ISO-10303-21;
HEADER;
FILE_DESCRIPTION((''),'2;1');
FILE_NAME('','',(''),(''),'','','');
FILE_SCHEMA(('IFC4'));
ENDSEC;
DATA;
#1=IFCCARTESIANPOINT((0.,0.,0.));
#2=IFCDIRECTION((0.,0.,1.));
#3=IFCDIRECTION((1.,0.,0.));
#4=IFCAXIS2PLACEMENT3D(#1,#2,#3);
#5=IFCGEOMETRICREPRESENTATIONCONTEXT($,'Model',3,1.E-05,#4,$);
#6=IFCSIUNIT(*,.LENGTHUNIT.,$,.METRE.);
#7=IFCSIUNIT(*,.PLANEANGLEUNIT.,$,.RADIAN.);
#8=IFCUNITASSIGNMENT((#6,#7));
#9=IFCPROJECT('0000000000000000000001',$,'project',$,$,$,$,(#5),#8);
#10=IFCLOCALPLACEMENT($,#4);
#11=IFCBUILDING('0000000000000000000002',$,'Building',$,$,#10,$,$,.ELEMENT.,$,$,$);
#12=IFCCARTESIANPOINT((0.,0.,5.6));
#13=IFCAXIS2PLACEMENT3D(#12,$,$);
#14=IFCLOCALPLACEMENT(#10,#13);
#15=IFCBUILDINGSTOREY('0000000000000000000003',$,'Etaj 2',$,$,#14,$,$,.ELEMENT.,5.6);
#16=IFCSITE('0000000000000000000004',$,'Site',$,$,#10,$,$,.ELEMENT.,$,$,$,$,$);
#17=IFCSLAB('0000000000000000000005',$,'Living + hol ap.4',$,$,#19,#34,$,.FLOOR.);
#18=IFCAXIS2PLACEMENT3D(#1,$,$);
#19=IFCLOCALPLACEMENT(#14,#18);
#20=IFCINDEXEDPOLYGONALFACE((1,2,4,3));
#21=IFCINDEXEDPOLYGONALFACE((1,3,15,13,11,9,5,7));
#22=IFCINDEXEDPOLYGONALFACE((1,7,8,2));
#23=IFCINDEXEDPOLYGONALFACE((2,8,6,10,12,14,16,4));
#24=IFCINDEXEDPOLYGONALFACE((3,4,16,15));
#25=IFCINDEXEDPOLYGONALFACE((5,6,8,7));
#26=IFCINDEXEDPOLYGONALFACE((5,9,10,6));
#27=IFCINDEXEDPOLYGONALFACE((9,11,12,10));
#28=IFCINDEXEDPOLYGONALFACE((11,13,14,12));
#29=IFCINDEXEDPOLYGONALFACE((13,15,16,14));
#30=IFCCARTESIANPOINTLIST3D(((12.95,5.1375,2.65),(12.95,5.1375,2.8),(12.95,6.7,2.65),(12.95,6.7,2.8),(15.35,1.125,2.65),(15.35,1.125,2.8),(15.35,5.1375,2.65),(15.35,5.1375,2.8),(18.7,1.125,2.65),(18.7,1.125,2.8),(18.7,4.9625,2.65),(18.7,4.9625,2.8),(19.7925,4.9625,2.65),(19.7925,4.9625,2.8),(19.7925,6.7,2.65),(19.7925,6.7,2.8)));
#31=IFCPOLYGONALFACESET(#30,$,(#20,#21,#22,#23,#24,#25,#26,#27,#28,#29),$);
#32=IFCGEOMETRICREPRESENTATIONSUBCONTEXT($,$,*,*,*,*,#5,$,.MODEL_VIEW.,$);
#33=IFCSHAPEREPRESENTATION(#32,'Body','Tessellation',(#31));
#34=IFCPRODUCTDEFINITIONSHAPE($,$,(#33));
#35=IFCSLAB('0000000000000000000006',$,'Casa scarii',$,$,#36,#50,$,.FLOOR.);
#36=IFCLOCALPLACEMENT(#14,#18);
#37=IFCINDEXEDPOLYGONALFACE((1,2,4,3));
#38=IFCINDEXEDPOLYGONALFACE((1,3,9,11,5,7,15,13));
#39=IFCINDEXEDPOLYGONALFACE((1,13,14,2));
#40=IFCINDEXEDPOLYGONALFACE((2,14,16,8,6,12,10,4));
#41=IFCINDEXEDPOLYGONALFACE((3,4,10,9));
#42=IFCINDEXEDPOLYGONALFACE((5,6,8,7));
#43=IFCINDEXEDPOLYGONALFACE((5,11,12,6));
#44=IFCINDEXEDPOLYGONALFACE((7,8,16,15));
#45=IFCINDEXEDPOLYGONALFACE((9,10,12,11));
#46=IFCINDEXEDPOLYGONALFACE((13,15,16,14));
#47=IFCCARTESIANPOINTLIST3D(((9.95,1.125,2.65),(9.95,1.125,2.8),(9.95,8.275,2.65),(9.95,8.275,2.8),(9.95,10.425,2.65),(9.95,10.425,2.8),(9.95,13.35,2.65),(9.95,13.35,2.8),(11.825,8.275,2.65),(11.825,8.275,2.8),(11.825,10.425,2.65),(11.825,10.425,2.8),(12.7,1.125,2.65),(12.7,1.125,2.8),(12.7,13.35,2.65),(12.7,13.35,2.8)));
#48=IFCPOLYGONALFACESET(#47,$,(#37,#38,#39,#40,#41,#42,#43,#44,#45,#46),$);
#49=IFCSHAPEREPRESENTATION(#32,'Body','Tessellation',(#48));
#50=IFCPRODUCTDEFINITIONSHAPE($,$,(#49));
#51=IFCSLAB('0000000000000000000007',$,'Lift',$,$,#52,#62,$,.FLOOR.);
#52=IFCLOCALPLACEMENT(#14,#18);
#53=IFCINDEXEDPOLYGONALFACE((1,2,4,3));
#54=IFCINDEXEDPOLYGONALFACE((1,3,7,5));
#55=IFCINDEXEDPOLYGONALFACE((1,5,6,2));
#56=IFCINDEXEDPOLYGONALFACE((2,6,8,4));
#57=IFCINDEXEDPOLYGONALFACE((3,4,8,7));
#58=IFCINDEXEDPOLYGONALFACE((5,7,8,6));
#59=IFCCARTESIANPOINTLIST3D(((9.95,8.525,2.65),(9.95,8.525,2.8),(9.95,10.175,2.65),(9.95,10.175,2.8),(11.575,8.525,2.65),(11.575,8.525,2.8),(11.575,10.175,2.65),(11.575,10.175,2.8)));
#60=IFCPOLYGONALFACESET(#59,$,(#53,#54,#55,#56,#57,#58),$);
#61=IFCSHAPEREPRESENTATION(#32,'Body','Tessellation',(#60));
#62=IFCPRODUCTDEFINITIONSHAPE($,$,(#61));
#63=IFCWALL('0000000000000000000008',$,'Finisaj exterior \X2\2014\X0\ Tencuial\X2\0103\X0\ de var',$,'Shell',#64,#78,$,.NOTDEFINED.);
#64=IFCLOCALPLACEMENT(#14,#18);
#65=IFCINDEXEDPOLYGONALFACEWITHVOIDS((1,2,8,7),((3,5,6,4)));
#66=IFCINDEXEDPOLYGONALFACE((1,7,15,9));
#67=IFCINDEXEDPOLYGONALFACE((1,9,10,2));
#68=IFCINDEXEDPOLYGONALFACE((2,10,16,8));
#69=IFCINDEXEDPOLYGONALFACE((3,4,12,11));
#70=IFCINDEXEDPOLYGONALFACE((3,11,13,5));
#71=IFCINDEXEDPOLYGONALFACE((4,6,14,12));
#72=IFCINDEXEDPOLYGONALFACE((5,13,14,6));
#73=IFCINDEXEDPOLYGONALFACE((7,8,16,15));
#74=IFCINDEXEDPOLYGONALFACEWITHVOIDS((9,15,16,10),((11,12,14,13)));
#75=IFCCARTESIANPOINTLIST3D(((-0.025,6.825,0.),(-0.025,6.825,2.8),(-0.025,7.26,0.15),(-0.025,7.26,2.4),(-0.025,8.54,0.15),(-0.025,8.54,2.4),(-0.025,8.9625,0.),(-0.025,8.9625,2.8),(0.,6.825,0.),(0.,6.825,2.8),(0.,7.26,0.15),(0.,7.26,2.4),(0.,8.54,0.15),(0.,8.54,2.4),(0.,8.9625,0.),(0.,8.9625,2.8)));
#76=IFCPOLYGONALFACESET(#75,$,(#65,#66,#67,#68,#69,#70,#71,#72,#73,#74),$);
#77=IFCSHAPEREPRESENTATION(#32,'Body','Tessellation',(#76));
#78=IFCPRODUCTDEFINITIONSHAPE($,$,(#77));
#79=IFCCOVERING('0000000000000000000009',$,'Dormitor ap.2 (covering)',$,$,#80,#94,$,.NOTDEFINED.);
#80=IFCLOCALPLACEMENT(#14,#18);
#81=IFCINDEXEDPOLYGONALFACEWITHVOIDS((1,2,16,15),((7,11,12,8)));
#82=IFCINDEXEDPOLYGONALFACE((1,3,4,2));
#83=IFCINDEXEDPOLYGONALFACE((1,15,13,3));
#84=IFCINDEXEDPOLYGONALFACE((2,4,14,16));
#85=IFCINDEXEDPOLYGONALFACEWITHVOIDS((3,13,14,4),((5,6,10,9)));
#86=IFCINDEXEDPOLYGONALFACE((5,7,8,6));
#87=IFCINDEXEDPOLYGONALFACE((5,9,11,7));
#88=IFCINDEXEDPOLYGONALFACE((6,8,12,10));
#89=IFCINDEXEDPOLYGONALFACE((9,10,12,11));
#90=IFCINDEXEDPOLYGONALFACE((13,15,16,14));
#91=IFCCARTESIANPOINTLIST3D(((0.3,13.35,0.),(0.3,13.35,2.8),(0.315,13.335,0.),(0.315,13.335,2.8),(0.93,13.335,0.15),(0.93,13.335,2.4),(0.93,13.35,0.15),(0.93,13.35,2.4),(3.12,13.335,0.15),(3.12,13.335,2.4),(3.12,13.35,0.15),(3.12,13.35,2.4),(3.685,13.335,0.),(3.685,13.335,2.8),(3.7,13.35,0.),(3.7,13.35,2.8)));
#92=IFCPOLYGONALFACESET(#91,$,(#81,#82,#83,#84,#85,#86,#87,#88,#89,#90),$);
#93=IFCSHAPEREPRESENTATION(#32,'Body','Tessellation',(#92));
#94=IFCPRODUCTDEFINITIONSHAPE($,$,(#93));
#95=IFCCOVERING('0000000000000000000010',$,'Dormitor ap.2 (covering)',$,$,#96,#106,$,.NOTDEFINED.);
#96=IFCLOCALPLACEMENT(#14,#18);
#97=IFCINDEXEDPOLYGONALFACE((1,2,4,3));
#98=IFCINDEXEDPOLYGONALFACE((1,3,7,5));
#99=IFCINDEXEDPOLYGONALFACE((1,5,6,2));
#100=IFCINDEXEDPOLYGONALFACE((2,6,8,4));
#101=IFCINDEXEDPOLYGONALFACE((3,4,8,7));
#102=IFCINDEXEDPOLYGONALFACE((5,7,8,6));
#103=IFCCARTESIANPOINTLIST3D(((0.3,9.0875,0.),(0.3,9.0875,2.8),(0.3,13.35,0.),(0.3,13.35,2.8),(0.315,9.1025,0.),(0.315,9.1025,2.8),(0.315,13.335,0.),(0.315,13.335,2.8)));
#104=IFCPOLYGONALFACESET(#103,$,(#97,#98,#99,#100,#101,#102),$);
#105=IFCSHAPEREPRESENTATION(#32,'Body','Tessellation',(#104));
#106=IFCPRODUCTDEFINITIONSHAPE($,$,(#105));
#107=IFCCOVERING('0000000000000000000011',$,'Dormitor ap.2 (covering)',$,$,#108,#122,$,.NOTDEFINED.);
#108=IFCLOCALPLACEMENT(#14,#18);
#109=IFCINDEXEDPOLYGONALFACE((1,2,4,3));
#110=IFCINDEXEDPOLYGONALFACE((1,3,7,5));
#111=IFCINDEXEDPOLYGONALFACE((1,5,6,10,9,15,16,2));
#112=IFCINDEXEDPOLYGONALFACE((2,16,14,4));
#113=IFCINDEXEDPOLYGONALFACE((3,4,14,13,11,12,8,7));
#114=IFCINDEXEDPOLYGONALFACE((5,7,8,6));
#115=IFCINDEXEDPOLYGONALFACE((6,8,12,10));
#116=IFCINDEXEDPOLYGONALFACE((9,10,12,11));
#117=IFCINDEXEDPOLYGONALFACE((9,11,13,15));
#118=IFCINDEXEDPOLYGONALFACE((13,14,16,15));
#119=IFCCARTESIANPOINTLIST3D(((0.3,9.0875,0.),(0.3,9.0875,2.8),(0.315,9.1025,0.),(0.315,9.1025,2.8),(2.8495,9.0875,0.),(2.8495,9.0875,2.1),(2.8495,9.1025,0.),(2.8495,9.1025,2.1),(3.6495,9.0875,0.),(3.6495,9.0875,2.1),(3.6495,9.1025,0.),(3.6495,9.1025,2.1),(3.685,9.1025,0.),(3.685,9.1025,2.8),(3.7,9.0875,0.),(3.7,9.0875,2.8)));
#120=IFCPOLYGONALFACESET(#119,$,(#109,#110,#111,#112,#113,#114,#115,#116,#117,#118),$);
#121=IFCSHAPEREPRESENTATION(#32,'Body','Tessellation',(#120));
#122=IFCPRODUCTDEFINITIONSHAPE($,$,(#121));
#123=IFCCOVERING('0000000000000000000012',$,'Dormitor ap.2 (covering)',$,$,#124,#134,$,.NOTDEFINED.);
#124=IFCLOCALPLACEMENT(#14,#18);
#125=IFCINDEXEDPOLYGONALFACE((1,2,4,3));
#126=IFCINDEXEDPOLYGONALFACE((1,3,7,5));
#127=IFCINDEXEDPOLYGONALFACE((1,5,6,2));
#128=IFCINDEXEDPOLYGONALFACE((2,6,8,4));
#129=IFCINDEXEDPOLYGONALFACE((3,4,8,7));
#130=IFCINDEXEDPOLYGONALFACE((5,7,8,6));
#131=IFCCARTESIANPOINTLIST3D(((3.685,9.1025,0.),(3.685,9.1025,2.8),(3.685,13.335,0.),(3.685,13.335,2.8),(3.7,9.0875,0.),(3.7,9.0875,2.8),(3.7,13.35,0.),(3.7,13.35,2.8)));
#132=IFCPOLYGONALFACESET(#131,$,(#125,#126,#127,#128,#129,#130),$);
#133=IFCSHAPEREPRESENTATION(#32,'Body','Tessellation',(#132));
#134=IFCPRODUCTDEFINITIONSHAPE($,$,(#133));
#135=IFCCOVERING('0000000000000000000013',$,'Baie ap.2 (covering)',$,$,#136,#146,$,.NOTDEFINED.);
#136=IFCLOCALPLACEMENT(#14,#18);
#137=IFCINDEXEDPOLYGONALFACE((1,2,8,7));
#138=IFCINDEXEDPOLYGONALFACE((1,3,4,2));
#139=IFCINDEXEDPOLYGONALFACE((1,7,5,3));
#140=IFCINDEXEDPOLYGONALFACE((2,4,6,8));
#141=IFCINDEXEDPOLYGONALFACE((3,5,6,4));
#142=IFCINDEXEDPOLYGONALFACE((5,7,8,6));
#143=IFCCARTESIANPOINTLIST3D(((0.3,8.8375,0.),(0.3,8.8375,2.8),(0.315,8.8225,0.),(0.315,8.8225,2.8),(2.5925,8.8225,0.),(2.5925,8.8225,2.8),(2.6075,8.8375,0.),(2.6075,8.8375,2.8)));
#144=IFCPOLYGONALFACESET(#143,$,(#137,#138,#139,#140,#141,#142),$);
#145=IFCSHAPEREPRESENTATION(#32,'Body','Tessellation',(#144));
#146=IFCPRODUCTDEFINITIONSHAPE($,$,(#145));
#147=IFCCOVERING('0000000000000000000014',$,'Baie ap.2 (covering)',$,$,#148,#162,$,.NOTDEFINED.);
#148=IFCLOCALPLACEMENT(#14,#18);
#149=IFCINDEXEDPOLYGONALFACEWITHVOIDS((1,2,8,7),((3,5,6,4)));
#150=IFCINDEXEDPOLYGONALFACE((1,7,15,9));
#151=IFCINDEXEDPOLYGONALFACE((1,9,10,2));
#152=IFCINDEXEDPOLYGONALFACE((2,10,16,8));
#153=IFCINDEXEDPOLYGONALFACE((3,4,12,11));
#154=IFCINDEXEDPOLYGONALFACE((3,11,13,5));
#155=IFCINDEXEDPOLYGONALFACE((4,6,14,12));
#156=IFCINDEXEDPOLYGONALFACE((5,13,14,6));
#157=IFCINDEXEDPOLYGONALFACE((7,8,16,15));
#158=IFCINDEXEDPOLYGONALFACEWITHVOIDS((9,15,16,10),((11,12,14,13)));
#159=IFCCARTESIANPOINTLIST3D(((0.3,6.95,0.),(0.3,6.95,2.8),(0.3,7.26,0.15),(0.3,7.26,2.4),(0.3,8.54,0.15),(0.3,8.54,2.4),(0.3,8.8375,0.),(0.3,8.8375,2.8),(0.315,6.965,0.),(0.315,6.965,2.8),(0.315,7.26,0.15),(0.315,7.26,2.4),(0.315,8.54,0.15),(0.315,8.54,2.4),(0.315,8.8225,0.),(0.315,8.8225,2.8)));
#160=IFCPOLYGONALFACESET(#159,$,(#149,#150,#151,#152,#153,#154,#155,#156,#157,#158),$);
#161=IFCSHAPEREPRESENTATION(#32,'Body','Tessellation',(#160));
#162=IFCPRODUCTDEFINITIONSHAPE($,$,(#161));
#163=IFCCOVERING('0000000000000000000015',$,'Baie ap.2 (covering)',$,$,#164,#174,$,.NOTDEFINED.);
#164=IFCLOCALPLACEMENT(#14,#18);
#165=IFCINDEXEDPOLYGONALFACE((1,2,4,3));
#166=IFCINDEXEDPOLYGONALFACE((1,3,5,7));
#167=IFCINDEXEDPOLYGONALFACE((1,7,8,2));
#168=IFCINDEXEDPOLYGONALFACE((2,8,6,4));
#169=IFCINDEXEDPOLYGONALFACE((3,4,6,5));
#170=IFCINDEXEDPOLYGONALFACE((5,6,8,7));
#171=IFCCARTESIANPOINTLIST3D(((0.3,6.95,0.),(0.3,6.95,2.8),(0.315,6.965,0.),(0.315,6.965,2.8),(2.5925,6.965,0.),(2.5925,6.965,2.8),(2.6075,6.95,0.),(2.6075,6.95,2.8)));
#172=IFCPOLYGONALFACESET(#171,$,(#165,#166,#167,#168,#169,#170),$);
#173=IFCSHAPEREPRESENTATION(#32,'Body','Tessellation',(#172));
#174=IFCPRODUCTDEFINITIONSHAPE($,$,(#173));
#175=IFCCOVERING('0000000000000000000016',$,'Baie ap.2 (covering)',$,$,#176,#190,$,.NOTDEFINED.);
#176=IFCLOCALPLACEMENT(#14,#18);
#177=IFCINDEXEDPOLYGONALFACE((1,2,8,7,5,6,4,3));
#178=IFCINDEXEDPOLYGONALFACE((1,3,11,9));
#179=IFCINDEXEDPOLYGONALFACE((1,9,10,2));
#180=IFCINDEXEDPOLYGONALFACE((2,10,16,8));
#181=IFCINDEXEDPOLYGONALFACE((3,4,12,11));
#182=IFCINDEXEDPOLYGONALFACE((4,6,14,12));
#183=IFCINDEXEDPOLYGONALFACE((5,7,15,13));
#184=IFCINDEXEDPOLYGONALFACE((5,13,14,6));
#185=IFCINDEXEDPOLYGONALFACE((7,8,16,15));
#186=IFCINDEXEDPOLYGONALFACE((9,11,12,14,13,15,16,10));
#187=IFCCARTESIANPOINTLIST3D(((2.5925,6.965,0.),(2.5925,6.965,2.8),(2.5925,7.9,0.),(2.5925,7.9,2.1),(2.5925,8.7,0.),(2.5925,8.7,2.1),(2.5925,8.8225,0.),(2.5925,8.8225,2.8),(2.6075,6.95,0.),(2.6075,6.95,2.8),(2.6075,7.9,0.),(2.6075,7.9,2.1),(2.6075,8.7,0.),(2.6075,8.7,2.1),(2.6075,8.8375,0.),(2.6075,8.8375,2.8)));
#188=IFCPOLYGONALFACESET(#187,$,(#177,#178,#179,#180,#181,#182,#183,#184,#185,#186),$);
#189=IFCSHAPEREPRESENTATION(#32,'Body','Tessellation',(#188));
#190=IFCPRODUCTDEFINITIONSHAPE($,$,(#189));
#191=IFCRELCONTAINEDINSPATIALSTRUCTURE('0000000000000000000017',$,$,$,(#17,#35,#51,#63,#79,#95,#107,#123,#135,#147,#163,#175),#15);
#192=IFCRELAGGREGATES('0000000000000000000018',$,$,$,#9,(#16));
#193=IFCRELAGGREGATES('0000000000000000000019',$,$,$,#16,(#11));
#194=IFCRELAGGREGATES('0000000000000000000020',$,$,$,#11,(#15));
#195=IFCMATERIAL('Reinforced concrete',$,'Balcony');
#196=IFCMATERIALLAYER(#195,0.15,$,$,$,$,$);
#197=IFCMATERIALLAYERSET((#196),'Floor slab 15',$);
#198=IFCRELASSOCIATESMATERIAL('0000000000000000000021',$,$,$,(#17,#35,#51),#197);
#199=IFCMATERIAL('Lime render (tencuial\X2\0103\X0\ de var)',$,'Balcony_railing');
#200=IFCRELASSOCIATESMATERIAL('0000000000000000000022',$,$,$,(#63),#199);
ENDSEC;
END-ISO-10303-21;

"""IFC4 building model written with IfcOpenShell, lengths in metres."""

from ifc_helpers import new_model, si_unit, frame, origin, origin_with_axes, origin_2d, place, context, subcontext, project, spatial, polyline, rectangle, outline, extrude, material, layer, layer_set, layer_usage, element, save


model = new_model("IFC4")

# Units and contexts
model_context = context("Model", 3, precision=1e-05, world=origin_with_axes())
sub_context = subcontext(model_context, None, None, "MODEL_VIEW")
ifc_project = project(units=[si_unit("LENGTHUNIT", "METRE"), si_unit("PLANEANGLEUNIT", "RADIAN")], contexts=[model_context])

# Site, building, storey
placement = place(None, origin_with_axes())
site = spatial("IfcSite", under=ifc_project, at=placement, Name="Site", CompositionType="ELEMENT")
building = spatial("IfcBuilding", under=site, at=placement, Name="Building", CompositionType="ELEMENT")
storey_placement = place(placement, frame((0.0, 0.0, 5.6)))
storey = spatial("IfcBuildingStorey", under=building, at=storey_placement, Name="Etaj 2", CompositionType="ELEMENT", Elevation=5.6)

# Slabs
ifc_material_1 = material(Name="Reinforced concrete", Category="Balcony")
ifc_layer = layer(ifc_material_1, 0.15)
ifc_layer_set = layer_set([ifc_layer], Name="Floor slab 15")
ifc_layer_usage = layer_usage(ifc_layer_set, "AXIS3", "POSITIVE", 0.0)
slab_1_placement = place(storey_placement, frame((0.0, 0.0, 2.65)))
element("IfcSlab", 1, at=slab_1_placement, inside=storey, material=ifc_layer_usage, Name="Living + hol ap.4", PredefinedType="FLOOR", context=sub_context, shape_type="SweptSolid", body=[
    extrude(outline(polyline([(18.7, 4.9625), (19.7925, 4.9625), (19.7925, 6.7), (12.95, 6.7), (12.95, 5.1375), (15.35, 5.1375), (15.35, 1.125), (18.7, 1.125), (18.7, 4.9625)])), origin(), (0.0, 0.0, 1.0), 0.15),
])
slab_2_placement = place(storey_placement, frame((0.0, 0.0, 2.65)))
element("IfcSlab", 2, at=slab_2_placement, inside=storey, material=ifc_layer_usage, Name="Casa scarii", PredefinedType="FLOOR", context=sub_context, shape_type="SweptSolid", body=[
    extrude(outline(polyline([(9.95, 13.35), (9.95, 10.425), (11.825, 10.425), (11.825, 8.275), (9.95, 8.275), (9.95, 1.125), (12.7, 1.125), (12.7, 13.35), (9.95, 13.35)])), origin(), (0.0, 0.0, 1.0), 0.15),
])
slab_3_placement = place(storey_placement, frame((0.0, 0.0, 2.65)))
element("IfcSlab", 3, at=slab_3_placement, inside=storey, material=ifc_layer_usage, Name="Lift", PredefinedType="FLOOR", context=sub_context, shape_type="SweptSolid", body=[
    extrude(outline(polyline([(11.575, 10.175), (9.95, 10.175), (9.95, 8.525), (11.575, 8.525), (11.575, 10.175)])), origin(), (0.0, 0.0, 1.0), 0.15),
])

# Wall, opening
ifc_material_2 = material(Name="Lime render (tencuială de var)", Category="Balcony_railing")
wall_placement = place(storey_placement, origin_with_axes())
wall = element("IfcWall", 4, at=wall_placement, inside=storey, material=ifc_material_2, Name="Finisaj exterior — Tencuială de var", ObjectType="Shell", PredefinedType="NOTDEFINED", context=sub_context, shape_type="SweptSolid", body=[
    extrude(outline(polyline([(-0.025, 8.9625), (-0.025, 6.825), (0.0, 6.825), (0.0, 8.9625), (-0.025, 8.9625)])), origin(), (0.0, 0.0, 1.0), 2.8),
])
opening_1_placement = place(wall_placement, frame((-0.075, 7.9, 0.15), z_axis=(1.0, 0.0, 0.0), x_axis=(0.0, 1.0, 0.0)))
element("IfcOpeningElement", 5, at=opening_1_placement, cuts=wall, PredefinedType="OPENING", context=sub_context, shape_type="SweptSolid", body=[
    extrude(rectangle(XDim=1.28, YDim=2.25, at=origin_2d()), frame((0.0, 1.125, 0.0)), (0.0, 0.0, 1.0), 0.5),
])

# Covering, opening
covering_1_placement = place(storey_placement, origin_with_axes())
covering_1 = element("IfcCovering", 6, at=covering_1_placement, inside=storey, Name="Dormitor ap.2 (covering)", PredefinedType="NOTDEFINED", context=sub_context, shape_type="SweptSolid", body=[
    extrude(outline(polyline([(3.7, 13.35), (0.3, 13.35), (0.315, 13.335), (3.685, 13.335), (3.7, 13.35)])), origin(), (0.0, 0.0, 1.0), 2.8),
])
opening_2_placement = place(covering_1_placement, frame((2.025, 13.665, 0.15), z_axis=(0.0, -1.0, 0.0), x_axis=(1.0, 0.0, 0.0)))
element("IfcOpeningElement", 7, at=opening_2_placement, cuts=covering_1, PredefinedType="OPENING", context=sub_context, shape_type="SweptSolid", body=[
    extrude(rectangle(XDim=2.19, YDim=2.25, at=origin_2d()), frame((0.0, 1.125, 0.0)), (0.0, 0.0, 1.0), 0.38),
])

# Covering
covering_2_placement = place(storey_placement, origin_with_axes())
element("IfcCovering", 8, at=covering_2_placement, inside=storey, Name="Dormitor ap.2 (covering)", PredefinedType="NOTDEFINED", context=sub_context, shape_type="SweptSolid", body=[
    extrude(outline(polyline([(0.3, 13.35), (0.3, 9.0875), (0.315, 9.1025), (0.315, 13.335), (0.3, 13.35)])), origin(), (0.0, 0.0, 1.0), 2.8),
])

# Covering, opening
covering_3_placement = place(storey_placement, origin_with_axes())
covering_3 = element("IfcCovering", 9, at=covering_3_placement, inside=storey, Name="Dormitor ap.2 (covering)", PredefinedType="NOTDEFINED", context=sub_context, shape_type="SweptSolid", body=[
    extrude(outline(polyline([(0.3, 9.0875), (3.7, 9.0875), (3.685, 9.1025), (0.315, 9.1025), (0.3, 9.0875)])), origin(), (0.0, 0.0, 1.0), 2.8),
])
opening_3_placement = place(covering_3_placement, frame((3.2495, 9.1525, 0.0), z_axis=(0.0, -1.0, 0.0), x_axis=(1.0, 0.0, 0.0)))
element("IfcOpeningElement", 10, at=opening_3_placement, cuts=covering_3, PredefinedType="OPENING", context=sub_context, shape_type="SweptSolid", body=[
    extrude(rectangle(XDim=0.8, YDim=2.1, at=origin_2d()), frame((0.0, 1.05, 0.0)), (0.0, 0.0, 1.0), 0.38),
])

# Coverings
covering_4_placement = place(storey_placement, origin_with_axes())
element("IfcCovering", 11, at=covering_4_placement, inside=storey, Name="Dormitor ap.2 (covering)", PredefinedType="NOTDEFINED", context=sub_context, shape_type="SweptSolid", body=[
    extrude(outline(polyline([(3.7, 9.0875), (3.7, 13.35), (3.685, 13.335), (3.685, 9.1025), (3.7, 9.0875)])), origin(), (0.0, 0.0, 1.0), 2.8),
])
covering_5_placement = place(storey_placement, origin_with_axes())
element("IfcCovering", 12, at=covering_5_placement, inside=storey, Name="Baie ap.2 (covering)", PredefinedType="NOTDEFINED", context=sub_context, shape_type="SweptSolid", body=[
    extrude(outline(polyline([(2.6075, 8.8375), (0.3, 8.8375), (0.315, 8.8225), (2.5925, 8.8225), (2.6075, 8.8375)])), origin(), (0.0, 0.0, 1.0), 2.8),
])

# Covering, opening
covering_6_placement = place(storey_placement, origin_with_axes())
covering_6 = element("IfcCovering", 13, at=covering_6_placement, inside=storey, Name="Baie ap.2 (covering)", PredefinedType="NOTDEFINED", context=sub_context, shape_type="SweptSolid", body=[
    extrude(outline(polyline([(0.3, 8.8375), (0.3, 6.95), (0.315, 6.965), (0.315, 8.8225), (0.3, 8.8375)])), origin(), (0.0, 0.0, 1.0), 2.8),
])
opening_4_placement = place(covering_6_placement, frame((-0.015, 7.9, 0.15), z_axis=(1.0, 0.0, 0.0), x_axis=(0.0, 1.0, 0.0)))
element("IfcOpeningElement", 14, at=opening_4_placement, cuts=covering_6, PredefinedType="OPENING", context=sub_context, shape_type="SweptSolid", body=[
    extrude(rectangle(XDim=1.28, YDim=2.25, at=origin_2d()), frame((0.0, 1.125, 0.0)), (0.0, 0.0, 1.0), 0.38),
])

# Covering
covering_7_placement = place(storey_placement, origin_with_axes())
element("IfcCovering", 15, at=covering_7_placement, inside=storey, Name="Baie ap.2 (covering)", PredefinedType="NOTDEFINED", context=sub_context, shape_type="SweptSolid", body=[
    extrude(outline(polyline([(0.3, 6.95), (2.6075, 6.95), (2.5925, 6.965), (0.315, 6.965), (0.3, 6.95)])), origin(), (0.0, 0.0, 1.0), 2.8),
])

# Covering, opening
covering_8_placement = place(storey_placement, origin_with_axes())
covering_8 = element("IfcCovering", 16, at=covering_8_placement, inside=storey, Name="Baie ap.2 (covering)", PredefinedType="NOTDEFINED", context=sub_context, shape_type="SweptSolid", body=[
    extrude(outline(polyline([(2.6075, 6.95), (2.6075, 8.8375), (2.5925, 8.8225), (2.5925, 6.965), (2.6075, 6.95)])), origin(), (0.0, 0.0, 1.0), 2.8),
])
opening_5_placement = place(covering_8_placement, frame((2.5425, 8.3, 0.0), z_axis=(1.0, 0.0, 0.0), x_axis=(0.0, 1.0, 0.0)))
element("IfcOpeningElement", 17, at=opening_5_placement, cuts=covering_8, PredefinedType="OPENING", context=sub_context, shape_type="SweptSolid", body=[
    extrude(rectangle(XDim=0.8, YDim=2.1, at=origin_2d()), frame((0.0, 1.05, 0.0)), (0.0, 0.0, 1.0), 0.38),
])

save(model, "model.ifc")
